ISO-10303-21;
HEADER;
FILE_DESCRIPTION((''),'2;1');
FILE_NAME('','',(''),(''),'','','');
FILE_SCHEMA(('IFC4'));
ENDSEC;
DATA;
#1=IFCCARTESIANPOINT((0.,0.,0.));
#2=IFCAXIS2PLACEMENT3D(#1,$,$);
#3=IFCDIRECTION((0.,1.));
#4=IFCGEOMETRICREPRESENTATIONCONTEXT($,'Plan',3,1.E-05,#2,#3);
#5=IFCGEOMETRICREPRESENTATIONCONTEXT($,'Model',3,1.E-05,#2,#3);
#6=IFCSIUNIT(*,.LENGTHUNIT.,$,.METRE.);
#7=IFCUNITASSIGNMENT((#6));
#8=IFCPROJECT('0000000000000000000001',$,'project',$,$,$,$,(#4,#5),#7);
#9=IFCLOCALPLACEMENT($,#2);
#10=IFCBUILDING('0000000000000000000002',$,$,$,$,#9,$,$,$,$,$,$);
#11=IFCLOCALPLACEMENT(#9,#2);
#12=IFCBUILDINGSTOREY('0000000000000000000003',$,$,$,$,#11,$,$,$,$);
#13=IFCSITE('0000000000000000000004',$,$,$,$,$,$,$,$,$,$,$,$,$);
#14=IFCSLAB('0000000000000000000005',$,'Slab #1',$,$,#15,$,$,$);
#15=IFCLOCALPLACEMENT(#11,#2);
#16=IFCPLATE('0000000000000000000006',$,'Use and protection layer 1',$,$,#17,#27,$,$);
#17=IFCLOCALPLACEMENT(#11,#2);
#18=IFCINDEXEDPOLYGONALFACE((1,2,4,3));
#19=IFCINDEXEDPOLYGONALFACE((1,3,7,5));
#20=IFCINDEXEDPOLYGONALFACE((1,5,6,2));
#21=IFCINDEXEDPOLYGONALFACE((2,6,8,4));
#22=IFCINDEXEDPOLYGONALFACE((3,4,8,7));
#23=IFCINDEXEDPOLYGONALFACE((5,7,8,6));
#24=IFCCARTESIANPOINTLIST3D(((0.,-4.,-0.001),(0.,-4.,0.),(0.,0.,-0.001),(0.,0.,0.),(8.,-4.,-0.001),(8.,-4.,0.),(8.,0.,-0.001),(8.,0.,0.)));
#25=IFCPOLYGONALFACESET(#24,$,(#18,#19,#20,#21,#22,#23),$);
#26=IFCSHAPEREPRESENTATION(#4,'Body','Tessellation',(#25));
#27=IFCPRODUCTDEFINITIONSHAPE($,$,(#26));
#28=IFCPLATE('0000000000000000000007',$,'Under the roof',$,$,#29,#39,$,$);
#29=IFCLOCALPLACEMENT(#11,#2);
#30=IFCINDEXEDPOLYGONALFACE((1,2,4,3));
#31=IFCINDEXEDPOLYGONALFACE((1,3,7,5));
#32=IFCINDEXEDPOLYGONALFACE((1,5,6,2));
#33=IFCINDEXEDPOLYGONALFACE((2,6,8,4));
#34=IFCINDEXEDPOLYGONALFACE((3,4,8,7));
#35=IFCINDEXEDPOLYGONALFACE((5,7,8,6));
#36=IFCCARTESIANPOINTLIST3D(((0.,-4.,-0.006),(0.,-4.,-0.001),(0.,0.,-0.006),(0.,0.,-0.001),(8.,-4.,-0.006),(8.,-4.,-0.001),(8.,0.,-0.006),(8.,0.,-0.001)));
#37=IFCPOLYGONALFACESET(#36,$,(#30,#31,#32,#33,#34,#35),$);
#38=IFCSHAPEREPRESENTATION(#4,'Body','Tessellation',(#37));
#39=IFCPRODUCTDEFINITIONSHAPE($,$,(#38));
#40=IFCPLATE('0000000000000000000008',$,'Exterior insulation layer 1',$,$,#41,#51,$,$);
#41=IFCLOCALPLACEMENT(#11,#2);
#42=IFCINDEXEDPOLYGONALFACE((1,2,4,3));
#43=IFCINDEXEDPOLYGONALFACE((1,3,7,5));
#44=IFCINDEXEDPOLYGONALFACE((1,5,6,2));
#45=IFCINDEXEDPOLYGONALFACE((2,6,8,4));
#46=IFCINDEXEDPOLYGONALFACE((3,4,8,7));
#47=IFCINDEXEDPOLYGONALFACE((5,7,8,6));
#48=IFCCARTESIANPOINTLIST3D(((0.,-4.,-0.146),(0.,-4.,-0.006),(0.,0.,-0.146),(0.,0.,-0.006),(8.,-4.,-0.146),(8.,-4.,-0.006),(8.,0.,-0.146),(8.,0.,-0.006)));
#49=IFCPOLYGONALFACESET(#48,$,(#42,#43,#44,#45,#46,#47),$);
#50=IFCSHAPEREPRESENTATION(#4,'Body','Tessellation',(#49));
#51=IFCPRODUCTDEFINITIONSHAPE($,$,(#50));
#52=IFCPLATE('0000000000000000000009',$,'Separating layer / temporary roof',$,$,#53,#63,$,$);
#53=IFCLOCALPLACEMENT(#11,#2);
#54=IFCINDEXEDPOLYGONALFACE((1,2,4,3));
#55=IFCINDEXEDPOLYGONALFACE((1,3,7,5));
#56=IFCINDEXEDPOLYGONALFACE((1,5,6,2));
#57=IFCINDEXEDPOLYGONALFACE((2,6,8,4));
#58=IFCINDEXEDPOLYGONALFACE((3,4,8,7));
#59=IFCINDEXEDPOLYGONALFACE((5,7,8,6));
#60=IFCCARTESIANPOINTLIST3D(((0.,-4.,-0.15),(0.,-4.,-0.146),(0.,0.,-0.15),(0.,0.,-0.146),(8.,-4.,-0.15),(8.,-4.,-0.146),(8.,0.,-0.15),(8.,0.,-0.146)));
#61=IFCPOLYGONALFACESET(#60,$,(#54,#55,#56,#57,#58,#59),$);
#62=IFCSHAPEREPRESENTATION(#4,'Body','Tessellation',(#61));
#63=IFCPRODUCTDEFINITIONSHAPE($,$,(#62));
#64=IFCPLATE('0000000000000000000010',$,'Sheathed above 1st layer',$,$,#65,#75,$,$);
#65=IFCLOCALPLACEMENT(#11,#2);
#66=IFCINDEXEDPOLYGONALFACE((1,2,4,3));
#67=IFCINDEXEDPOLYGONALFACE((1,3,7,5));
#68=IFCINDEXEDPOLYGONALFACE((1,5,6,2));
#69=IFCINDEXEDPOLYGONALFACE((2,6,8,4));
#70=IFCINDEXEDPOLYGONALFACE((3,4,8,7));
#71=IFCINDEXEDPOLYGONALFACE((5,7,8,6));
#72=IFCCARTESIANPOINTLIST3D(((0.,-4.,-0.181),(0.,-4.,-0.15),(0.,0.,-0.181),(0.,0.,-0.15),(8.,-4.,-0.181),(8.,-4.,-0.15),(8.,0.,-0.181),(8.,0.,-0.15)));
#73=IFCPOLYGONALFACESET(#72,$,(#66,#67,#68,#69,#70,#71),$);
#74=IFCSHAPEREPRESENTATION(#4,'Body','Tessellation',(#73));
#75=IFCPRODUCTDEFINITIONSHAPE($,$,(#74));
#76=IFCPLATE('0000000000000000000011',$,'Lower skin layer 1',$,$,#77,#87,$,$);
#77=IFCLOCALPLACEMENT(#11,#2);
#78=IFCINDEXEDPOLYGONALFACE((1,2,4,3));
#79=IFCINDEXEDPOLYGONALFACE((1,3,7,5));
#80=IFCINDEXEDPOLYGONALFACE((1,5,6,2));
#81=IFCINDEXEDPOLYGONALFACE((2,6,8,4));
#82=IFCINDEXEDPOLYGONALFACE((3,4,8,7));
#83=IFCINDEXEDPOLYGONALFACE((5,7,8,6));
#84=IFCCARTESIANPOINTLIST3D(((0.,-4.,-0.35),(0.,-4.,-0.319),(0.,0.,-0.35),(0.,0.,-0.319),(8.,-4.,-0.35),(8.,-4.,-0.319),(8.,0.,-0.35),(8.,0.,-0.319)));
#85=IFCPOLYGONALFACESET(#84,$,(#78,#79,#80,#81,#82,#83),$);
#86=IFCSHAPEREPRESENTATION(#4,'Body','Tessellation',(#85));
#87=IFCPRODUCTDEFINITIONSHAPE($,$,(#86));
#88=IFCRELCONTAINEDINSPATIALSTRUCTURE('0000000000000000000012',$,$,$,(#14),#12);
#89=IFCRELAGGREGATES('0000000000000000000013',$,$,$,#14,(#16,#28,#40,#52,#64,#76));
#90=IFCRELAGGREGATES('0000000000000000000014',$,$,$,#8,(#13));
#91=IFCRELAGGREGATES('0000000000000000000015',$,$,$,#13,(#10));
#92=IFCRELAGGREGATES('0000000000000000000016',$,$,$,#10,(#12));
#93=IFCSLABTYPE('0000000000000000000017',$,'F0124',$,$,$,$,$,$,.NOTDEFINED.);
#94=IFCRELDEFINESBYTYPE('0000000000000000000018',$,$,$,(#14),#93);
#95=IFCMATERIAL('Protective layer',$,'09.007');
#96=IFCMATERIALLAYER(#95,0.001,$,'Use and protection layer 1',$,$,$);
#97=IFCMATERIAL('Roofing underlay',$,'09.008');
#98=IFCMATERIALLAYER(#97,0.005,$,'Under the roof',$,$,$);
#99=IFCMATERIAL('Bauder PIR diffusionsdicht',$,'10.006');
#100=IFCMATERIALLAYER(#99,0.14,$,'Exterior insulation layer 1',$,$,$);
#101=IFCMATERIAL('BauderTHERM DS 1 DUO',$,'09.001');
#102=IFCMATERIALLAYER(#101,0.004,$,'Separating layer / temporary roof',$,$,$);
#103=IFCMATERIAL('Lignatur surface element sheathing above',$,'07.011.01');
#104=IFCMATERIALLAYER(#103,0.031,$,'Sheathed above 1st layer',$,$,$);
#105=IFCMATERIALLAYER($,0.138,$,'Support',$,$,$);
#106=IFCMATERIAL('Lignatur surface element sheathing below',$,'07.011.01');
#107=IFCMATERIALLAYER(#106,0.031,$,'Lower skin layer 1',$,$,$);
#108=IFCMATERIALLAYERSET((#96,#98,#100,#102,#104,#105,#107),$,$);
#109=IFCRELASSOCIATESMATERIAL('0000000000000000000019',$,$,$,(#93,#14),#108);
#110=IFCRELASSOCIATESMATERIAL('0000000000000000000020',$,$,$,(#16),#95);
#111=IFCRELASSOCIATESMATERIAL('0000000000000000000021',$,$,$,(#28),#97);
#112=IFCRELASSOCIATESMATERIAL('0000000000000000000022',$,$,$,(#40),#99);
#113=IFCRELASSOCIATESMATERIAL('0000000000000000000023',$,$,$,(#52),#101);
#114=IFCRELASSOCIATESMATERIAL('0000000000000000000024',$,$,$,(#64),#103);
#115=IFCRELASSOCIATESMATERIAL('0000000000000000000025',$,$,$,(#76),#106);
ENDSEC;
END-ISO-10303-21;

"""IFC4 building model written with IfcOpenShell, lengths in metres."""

from ifc_helpers import new_model, si_unit, direction, frame, frame_2d, origin, origin_with_axes, place, context, project, spatial, rectangle, extrude, material, layer, layer_set, type_object, element, aggregate, save


model = new_model("IFC4")

# Units and contexts
plan_context = context("Plan", 3, precision=1e-05, world=origin(), true_north=direction((0.0, 1.0)))
model_context = context("Model", 3, precision=1e-05, world=origin(), true_north=direction((0.0, 1.0)))
ifc_project = project(units=[si_unit("LENGTHUNIT", "METRE")], contexts=[plan_context, model_context])

# Site, building, storey
site = spatial("IfcSite", under=ifc_project)
building_placement = place(None, origin())
building = spatial("IfcBuilding", under=site, at=building_placement)
storey_placement = place(building_placement, origin())
storey = spatial("IfcBuildingStorey", under=building, at=storey_placement)

# Slab, plates
ifc_material_1 = material(Name="Protective layer", Category="09.007")
ifc_layer_1 = layer(ifc_material_1, 0.001, Name="Use and protection layer 1")
ifc_material_2 = material(Name="Roofing underlay", Category="09.008")
ifc_layer_2 = layer(ifc_material_2, 0.005, Name="Under the roof")
ifc_material_3 = material(Name="Bauder PIR diffusionsdicht", Category="10.006")
ifc_layer_3 = layer(ifc_material_3, 0.14, Name="Exterior insulation layer 1")
ifc_material_4 = material(Name="BauderTHERM DS 1 DUO", Category="09.001")
ifc_layer_4 = layer(ifc_material_4, 0.004, Name="Separating layer / temporary roof")
ifc_material_5 = material(Name="Lignatur surface element sheathing above", Category="07.011.01")
ifc_layer_5 = layer(ifc_material_5, 0.031, Name="Sheathed above 1st layer")
ifc_layer_6 = layer(None, 0.138, Name="Support")
ifc_material_6 = material(Name="Lignatur surface element sheathing below", Category="07.011.01")
ifc_layer_7 = layer(ifc_material_6, 0.031, Name="Lower skin layer 1")
ifc_layer_set = layer_set([ifc_layer_1, ifc_layer_2, ifc_layer_3, ifc_layer_4, ifc_layer_5, ifc_layer_6, ifc_layer_7])
slab_type = type_object("IfcSlabType", Name="F0124", PredefinedType="NOTDEFINED", material=ifc_layer_set)
slab_placement = place(None, frame((0.0, 0.0, 0.0), z_axis=(0.0, 0.0, -1.0), x_axis=(1.0, 0.0, 0.0)))
slab = element("IfcSlab", 1, at=slab_placement, inside=storey, type_object=slab_type, material=ifc_layer_set, Name="Slab #1")
plate_1_placement = place(slab_placement, origin())
plate_1 = element("IfcPlate", 2, at=plate_1_placement, material=ifc_material_1, Name="Use and protection layer 1", context=plan_context, shape_type="SweptSolid", body=[
    extrude(rectangle(XDim=8.0, YDim=4.0, at=frame_2d((4.0, 2.0), x_axis=(1.0, 0.0))), origin_with_axes(), (0.0, 0.0, 1.0), 0.001),
])
plate_2_placement = place(slab_placement, origin())
plate_2 = element("IfcPlate", 3, at=plate_2_placement, material=ifc_material_2, Name="Under the roof", context=plan_context, shape_type="SweptSolid", body=[
    extrude(rectangle(XDim=8.0, YDim=4.0, at=frame_2d((4.0, 2.0), x_axis=(1.0, 0.0))), frame((0.0, 0.0, 0.001), z_axis=(0.0, 0.0, 1.0), x_axis=(1.0, 0.0, 0.0)), (0.0, 0.0, 1.0), 0.005),
])
plate_3_placement = place(slab_placement, origin())
plate_3 = element("IfcPlate", 4, at=plate_3_placement, material=ifc_material_3, Name="Exterior insulation layer 1", context=plan_context, shape_type="SweptSolid", body=[
    extrude(rectangle(XDim=8.0, YDim=4.0, at=frame_2d((4.0, 2.0), x_axis=(1.0, 0.0))), frame((0.0, 0.0, 0.006), z_axis=(0.0, 0.0, 1.0), x_axis=(1.0, 0.0, 0.0)), (0.0, 0.0, 1.0), 0.14),
])
plate_4_placement = place(slab_placement, origin())
plate_4 = element("IfcPlate", 5, at=plate_4_placement, material=ifc_material_4, Name="Separating layer / temporary roof", context=plan_context, shape_type="SweptSolid", body=[
    extrude(rectangle(XDim=8.0, YDim=4.0, at=frame_2d((4.0, 2.0), x_axis=(1.0, 0.0))), frame((0.0, 0.0, 0.146), z_axis=(0.0, 0.0, 1.0), x_axis=(1.0, 0.0, 0.0)), (0.0, 0.0, 1.0), 0.004),
])
plate_5_placement = place(slab_placement, origin())
plate_5 = element("IfcPlate", 6, at=plate_5_placement, material=ifc_material_5, Name="Sheathed above 1st layer", context=plan_context, shape_type="SweptSolid", body=[
    extrude(rectangle(XDim=8.0, YDim=4.0, at=frame_2d((4.0, 2.0), x_axis=(1.0, 0.0))), frame((0.0, 0.0, 0.15), z_axis=(0.0, 0.0, 1.0), x_axis=(1.0, 0.0, 0.0)), (0.0, 0.0, 1.0), 0.031),
])
plate_6_placement = place(slab_placement, origin())
plate_6 = element("IfcPlate", 7, at=plate_6_placement, material=ifc_material_6, Name="Lower skin layer 1", context=plan_context, shape_type="SweptSolid", body=[
    extrude(rectangle(XDim=8.0, YDim=4.0, at=frame_2d((4.0, 2.0), x_axis=(1.0, 0.0))), frame((0.0, 0.0, 0.319), z_axis=(0.0, 0.0, 1.0), x_axis=(1.0, 0.0, 0.0)), (0.0, 0.0, 1.0), 0.031),
])
aggregate(slab, [plate_1, plate_2, plate_3, plate_4, plate_5, plate_6])

save(model, "model.ifc")
